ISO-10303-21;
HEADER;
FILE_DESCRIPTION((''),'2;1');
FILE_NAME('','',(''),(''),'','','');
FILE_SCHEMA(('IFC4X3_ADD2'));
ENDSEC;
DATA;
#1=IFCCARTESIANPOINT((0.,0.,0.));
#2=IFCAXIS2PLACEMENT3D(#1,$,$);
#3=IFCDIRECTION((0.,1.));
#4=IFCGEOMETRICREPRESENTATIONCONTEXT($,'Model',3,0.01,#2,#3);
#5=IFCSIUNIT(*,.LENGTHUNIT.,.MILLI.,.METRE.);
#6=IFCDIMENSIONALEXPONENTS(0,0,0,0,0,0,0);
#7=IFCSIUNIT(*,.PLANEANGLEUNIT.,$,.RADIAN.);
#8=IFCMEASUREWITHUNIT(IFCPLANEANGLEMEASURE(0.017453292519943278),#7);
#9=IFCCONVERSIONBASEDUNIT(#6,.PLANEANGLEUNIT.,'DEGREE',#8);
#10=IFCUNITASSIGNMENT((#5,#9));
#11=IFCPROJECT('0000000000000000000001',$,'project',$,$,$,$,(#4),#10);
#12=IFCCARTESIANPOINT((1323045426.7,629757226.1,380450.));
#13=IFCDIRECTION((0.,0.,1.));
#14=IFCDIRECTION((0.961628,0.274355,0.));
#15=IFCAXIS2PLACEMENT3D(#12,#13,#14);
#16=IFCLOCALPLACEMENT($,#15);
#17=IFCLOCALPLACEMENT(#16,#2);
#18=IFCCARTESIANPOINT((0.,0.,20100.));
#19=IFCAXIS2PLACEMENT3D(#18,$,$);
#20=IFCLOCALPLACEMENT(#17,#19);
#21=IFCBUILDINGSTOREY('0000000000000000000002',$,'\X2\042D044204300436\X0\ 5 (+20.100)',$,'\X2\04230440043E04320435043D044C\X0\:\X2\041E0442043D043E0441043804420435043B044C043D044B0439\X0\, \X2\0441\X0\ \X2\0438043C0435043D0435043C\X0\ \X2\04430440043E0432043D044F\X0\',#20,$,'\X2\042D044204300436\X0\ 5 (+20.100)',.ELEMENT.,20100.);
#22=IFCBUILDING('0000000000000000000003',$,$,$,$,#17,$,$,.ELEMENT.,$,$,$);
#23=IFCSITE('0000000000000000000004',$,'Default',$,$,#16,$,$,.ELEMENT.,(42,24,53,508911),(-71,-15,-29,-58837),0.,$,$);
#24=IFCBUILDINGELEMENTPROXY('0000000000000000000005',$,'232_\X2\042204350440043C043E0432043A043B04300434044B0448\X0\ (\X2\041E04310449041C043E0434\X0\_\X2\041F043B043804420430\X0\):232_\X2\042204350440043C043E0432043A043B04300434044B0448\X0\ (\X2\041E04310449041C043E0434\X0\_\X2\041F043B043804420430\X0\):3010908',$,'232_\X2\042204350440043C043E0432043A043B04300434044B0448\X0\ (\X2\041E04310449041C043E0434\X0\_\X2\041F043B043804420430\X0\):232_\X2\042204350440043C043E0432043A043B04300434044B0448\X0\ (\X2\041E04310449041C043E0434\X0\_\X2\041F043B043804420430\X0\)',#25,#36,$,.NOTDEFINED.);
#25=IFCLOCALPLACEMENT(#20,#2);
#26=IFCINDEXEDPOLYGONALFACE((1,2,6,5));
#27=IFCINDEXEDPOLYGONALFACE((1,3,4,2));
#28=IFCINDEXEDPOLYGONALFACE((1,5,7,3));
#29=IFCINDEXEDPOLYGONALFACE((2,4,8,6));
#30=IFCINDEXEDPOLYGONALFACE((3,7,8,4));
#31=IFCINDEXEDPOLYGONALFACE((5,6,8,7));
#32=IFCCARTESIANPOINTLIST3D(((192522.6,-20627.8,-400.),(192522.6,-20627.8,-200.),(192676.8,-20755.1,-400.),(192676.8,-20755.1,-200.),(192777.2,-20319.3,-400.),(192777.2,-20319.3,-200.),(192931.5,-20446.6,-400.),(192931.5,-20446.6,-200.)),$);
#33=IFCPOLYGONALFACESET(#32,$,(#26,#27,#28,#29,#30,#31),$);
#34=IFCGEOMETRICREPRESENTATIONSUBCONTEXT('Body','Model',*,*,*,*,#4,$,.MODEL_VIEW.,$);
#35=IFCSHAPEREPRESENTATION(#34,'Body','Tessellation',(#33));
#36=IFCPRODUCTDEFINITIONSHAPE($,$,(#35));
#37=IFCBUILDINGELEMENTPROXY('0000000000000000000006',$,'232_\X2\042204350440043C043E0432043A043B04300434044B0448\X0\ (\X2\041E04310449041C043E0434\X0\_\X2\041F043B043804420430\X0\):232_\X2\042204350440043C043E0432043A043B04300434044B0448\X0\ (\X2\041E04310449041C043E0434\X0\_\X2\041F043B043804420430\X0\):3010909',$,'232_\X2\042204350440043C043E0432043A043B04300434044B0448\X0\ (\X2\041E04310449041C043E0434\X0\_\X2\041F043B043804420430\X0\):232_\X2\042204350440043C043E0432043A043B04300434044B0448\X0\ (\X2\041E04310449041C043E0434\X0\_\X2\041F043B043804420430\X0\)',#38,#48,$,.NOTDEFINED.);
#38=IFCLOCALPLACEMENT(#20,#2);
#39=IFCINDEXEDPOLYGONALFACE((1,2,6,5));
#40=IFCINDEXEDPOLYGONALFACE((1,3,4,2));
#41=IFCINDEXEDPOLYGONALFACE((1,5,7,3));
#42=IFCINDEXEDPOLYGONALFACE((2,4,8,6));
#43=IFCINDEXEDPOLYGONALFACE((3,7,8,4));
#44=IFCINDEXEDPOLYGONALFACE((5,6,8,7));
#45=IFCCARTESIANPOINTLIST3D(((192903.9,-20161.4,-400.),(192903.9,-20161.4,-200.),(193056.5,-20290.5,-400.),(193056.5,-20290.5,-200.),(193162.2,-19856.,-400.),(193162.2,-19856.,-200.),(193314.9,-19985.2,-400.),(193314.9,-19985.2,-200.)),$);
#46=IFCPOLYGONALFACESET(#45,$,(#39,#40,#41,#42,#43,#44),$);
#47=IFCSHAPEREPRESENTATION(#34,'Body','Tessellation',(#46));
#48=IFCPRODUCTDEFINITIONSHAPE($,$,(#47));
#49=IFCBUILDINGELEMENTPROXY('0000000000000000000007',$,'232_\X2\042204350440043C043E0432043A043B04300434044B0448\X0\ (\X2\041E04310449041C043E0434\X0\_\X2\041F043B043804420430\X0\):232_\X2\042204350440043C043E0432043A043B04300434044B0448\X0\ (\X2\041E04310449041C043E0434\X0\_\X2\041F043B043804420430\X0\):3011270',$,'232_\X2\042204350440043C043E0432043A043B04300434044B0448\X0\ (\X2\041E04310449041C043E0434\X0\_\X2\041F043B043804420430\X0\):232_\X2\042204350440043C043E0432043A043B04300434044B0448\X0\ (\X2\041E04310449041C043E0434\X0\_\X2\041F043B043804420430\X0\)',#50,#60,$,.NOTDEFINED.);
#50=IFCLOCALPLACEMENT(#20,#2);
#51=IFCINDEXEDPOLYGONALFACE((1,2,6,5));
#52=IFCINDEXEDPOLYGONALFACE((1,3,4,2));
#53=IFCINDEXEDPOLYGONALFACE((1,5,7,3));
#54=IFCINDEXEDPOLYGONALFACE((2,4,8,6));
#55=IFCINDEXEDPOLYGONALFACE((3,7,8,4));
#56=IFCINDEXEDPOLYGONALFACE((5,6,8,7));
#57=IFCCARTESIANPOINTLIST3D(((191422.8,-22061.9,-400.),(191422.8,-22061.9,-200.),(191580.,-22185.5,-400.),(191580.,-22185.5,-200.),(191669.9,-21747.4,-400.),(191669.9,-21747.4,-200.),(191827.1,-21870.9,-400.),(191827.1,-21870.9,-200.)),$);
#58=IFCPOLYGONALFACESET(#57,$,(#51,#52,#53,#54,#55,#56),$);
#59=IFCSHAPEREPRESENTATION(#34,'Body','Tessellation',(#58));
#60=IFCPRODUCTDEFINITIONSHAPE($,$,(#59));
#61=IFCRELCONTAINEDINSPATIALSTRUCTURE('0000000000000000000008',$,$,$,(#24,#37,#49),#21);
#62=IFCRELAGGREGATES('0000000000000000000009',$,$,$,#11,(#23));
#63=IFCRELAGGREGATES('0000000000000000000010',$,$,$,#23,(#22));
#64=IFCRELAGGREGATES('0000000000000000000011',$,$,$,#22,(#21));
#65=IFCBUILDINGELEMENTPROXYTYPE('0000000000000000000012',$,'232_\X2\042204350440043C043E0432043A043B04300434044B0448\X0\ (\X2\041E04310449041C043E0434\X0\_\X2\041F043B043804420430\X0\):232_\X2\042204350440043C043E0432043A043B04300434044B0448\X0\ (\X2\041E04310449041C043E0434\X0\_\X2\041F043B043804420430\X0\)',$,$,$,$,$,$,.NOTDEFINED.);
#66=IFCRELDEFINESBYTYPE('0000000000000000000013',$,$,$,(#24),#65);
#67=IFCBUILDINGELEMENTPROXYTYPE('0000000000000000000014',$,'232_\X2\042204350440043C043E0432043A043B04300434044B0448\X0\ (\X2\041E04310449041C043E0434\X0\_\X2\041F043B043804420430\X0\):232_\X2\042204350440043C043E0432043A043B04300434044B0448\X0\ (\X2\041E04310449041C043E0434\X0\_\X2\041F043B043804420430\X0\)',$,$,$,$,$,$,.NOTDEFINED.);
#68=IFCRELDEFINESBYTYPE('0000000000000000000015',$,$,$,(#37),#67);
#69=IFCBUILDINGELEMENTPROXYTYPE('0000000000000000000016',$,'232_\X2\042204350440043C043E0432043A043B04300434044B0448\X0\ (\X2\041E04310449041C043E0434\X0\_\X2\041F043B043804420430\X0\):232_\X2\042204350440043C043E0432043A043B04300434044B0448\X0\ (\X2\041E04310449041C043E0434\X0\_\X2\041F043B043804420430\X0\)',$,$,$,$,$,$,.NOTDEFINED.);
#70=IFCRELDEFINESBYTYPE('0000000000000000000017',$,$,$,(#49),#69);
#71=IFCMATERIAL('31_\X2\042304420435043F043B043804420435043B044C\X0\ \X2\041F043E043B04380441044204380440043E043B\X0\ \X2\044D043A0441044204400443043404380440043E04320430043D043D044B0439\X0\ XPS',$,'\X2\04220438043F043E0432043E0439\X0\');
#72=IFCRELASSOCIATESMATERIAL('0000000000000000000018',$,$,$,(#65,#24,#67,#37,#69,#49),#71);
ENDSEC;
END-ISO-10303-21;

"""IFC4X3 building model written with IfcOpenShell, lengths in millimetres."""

from ifc_helpers import new_model, entity, si_unit, converted_unit, direction, frame, frame_2d, origin, origin_2d_with_axis, place, context, subcontext, project, spatial, rectangle, extrude, source, transform, mapped, material, type_object, type_shapes, element, save


model = new_model("IFC4X3")

# Units and contexts
model_context = context("Model", 3, precision=0.01, world=origin(), true_north=direction((0.0, 1.0)))
body_context = subcontext(model_context, "Body", "Model", "MODEL_VIEW")
ifc_project = project(units=[si_unit("LENGTHUNIT", "METRE", prefix="MILLI"), converted_unit("PLANEANGLEUNIT", "DEGREE", entity("IfcPlaneAngleMeasure", 0.017453292519943278), si_unit("PLANEANGLEUNIT", "RADIAN"), dimensions=[0, 0, 0, 0, 0, 0, 0])], contexts=[model_context])

# Site, building, storey
site_placement = place(None, frame((1323045426.7, 629757226.1, 380450.0), z_axis=(0.0, 0.0, 1.0), x_axis=(0.961628, 0.274355, 0.0)))
site = spatial("IfcSite", under=ifc_project, at=site_placement, Name="Default", CompositionType="ELEMENT", RefLatitude=(42, 24, 53, 508911), RefLongitude=(-71, -15, -29, -58837), RefElevation=0.0)
building_placement = place(site_placement, origin())
building = spatial("IfcBuilding", under=site, at=building_placement, CompositionType="ELEMENT")
storey_placement = place(building_placement, frame((0.0, 0.0, 20100.0)))
storey = spatial("IfcBuildingStorey", under=building, at=storey_placement, Name="Этаж 5 (+20.100)", ObjectType="Уровень:Относительный, с именем уровня", LongName="Этаж 5 (+20.100)", CompositionType="ELEMENT", Elevation=20100.0)

# Building element proxies
ifc_material_1 = material(Name="31_Утеплитель Полистирол экструдированный XPS", Category="Типовой")
building_element_proxy_type_1 = type_object("IfcBuildingElementProxyType", Name="232_Термовкладыш (ОбщМод_Плита):232_Термовкладыш (ОбщМод_Плита)", PredefinedType="NOTDEFINED", material=ifc_material_1)
shared_shape_1 = source(origin(), body_context, "Body", "SweptSolid", [
    extrude(rectangle(XDim=400.0, YDim=200.0, at=frame_2d((0.0, 0.0), x_axis=(1.0, 0.0))), frame((192727.0, -20537.2, -200.0), z_axis=(0.0, 0.0, 1.0), x_axis=(0.636628, 0.771171, 0.0)), (0.0, 0.0, 1.0), 200.0),
])
type_shapes(building_element_proxy_type_1, [shared_shape_1])
proxy_1_placement = place(storey_placement, frame((0.0, 0.0, -200.0)))
element("IfcBuildingElementProxy", 1, at=proxy_1_placement, inside=storey, type_object=building_element_proxy_type_1, material=ifc_material_1, Name="232_Термовкладыш (ОбщМод_Плита):232_Термовкладыш (ОбщМод_Плита):3010908", ObjectType="232_Термовкладыш (ОбщМод_Плита):232_Термовкладыш (ОбщМод_Плита)", PredefinedType="NOTDEFINED", context=body_context, shape_type="MappedRepresentation", body=[
    mapped(shared_shape_1, transform((0.0, 0.0, 0.0), scale=1.0)),
])
building_element_proxy_type_2 = type_object("IfcBuildingElementProxyType", Name="232_Термовкладыш (ОбщМод_Плита):232_Термовкладыш (ОбщМод_Плита)", PredefinedType="NOTDEFINED", material=ifc_material_1)
shared_shape_2 = source(origin(), body_context, "Body", "SweptSolid", [
    extrude(rectangle(XDim=400.0, YDim=200.0, at=frame_2d((0.0, 0.0), x_axis=(1.0, 0.0))), frame((193109.4, -20073.3, -200.0), z_axis=(0.0, 0.0, 1.0), x_axis=(0.645917, 0.763408, 0.0)), (0.0, 0.0, 1.0), 200.0),
])
type_shapes(building_element_proxy_type_2, [shared_shape_2])
proxy_2_placement = place(storey_placement, frame((0.0, 0.0, -200.0)))
element("IfcBuildingElementProxy", 2, at=proxy_2_placement, inside=storey, type_object=building_element_proxy_type_2, material=ifc_material_1, Name="232_Термовкладыш (ОбщМод_Плита):232_Термовкладыш (ОбщМод_Плита):3010909", ObjectType="232_Термовкладыш (ОбщМод_Плита):232_Термовкладыш (ОбщМод_Плита)", PredefinedType="NOTDEFINED", context=body_context, shape_type="MappedRepresentation", body=[
    mapped(shared_shape_2, transform((0.0, 0.0, 0.0), scale=1.0)),
])
building_element_proxy_type_3 = type_object("IfcBuildingElementProxyType", Name="232_Термовкладыш (ОбщМод_Плита):232_Термовкладыш (ОбщМод_Плита)", PredefinedType="NOTDEFINED", material=ifc_material_1)
shared_shape_3 = source(origin(), body_context, "Body", "SweptSolid", [
    extrude(rectangle(XDim=400.0, YDim=200.0, at=origin_2d_with_axis()), frame((191624.9, -21966.4, -200.0), z_axis=(0.0, 0.0, 1.0), x_axis=(0.61777, 0.786358, 0.0)), (0.0, 0.0, 1.0), 200.0),
])
type_shapes(building_element_proxy_type_3, [shared_shape_3])
proxy_3_placement = place(storey_placement, frame((0.0, 0.0, -200.0)))
element("IfcBuildingElementProxy", 3, at=proxy_3_placement, inside=storey, type_object=building_element_proxy_type_3, material=ifc_material_1, Name="232_Термовкладыш (ОбщМод_Плита):232_Термовкладыш (ОбщМод_Плита):3011270", ObjectType="232_Термовкладыш (ОбщМод_Плита):232_Термовкладыш (ОбщМод_Плита)", PredefinedType="NOTDEFINED", context=body_context, shape_type="MappedRepresentation", body=[
    mapped(shared_shape_3, transform((0.0, 0.0, 0.0), scale=1.0)),
])

save(model, "model.ifc")
